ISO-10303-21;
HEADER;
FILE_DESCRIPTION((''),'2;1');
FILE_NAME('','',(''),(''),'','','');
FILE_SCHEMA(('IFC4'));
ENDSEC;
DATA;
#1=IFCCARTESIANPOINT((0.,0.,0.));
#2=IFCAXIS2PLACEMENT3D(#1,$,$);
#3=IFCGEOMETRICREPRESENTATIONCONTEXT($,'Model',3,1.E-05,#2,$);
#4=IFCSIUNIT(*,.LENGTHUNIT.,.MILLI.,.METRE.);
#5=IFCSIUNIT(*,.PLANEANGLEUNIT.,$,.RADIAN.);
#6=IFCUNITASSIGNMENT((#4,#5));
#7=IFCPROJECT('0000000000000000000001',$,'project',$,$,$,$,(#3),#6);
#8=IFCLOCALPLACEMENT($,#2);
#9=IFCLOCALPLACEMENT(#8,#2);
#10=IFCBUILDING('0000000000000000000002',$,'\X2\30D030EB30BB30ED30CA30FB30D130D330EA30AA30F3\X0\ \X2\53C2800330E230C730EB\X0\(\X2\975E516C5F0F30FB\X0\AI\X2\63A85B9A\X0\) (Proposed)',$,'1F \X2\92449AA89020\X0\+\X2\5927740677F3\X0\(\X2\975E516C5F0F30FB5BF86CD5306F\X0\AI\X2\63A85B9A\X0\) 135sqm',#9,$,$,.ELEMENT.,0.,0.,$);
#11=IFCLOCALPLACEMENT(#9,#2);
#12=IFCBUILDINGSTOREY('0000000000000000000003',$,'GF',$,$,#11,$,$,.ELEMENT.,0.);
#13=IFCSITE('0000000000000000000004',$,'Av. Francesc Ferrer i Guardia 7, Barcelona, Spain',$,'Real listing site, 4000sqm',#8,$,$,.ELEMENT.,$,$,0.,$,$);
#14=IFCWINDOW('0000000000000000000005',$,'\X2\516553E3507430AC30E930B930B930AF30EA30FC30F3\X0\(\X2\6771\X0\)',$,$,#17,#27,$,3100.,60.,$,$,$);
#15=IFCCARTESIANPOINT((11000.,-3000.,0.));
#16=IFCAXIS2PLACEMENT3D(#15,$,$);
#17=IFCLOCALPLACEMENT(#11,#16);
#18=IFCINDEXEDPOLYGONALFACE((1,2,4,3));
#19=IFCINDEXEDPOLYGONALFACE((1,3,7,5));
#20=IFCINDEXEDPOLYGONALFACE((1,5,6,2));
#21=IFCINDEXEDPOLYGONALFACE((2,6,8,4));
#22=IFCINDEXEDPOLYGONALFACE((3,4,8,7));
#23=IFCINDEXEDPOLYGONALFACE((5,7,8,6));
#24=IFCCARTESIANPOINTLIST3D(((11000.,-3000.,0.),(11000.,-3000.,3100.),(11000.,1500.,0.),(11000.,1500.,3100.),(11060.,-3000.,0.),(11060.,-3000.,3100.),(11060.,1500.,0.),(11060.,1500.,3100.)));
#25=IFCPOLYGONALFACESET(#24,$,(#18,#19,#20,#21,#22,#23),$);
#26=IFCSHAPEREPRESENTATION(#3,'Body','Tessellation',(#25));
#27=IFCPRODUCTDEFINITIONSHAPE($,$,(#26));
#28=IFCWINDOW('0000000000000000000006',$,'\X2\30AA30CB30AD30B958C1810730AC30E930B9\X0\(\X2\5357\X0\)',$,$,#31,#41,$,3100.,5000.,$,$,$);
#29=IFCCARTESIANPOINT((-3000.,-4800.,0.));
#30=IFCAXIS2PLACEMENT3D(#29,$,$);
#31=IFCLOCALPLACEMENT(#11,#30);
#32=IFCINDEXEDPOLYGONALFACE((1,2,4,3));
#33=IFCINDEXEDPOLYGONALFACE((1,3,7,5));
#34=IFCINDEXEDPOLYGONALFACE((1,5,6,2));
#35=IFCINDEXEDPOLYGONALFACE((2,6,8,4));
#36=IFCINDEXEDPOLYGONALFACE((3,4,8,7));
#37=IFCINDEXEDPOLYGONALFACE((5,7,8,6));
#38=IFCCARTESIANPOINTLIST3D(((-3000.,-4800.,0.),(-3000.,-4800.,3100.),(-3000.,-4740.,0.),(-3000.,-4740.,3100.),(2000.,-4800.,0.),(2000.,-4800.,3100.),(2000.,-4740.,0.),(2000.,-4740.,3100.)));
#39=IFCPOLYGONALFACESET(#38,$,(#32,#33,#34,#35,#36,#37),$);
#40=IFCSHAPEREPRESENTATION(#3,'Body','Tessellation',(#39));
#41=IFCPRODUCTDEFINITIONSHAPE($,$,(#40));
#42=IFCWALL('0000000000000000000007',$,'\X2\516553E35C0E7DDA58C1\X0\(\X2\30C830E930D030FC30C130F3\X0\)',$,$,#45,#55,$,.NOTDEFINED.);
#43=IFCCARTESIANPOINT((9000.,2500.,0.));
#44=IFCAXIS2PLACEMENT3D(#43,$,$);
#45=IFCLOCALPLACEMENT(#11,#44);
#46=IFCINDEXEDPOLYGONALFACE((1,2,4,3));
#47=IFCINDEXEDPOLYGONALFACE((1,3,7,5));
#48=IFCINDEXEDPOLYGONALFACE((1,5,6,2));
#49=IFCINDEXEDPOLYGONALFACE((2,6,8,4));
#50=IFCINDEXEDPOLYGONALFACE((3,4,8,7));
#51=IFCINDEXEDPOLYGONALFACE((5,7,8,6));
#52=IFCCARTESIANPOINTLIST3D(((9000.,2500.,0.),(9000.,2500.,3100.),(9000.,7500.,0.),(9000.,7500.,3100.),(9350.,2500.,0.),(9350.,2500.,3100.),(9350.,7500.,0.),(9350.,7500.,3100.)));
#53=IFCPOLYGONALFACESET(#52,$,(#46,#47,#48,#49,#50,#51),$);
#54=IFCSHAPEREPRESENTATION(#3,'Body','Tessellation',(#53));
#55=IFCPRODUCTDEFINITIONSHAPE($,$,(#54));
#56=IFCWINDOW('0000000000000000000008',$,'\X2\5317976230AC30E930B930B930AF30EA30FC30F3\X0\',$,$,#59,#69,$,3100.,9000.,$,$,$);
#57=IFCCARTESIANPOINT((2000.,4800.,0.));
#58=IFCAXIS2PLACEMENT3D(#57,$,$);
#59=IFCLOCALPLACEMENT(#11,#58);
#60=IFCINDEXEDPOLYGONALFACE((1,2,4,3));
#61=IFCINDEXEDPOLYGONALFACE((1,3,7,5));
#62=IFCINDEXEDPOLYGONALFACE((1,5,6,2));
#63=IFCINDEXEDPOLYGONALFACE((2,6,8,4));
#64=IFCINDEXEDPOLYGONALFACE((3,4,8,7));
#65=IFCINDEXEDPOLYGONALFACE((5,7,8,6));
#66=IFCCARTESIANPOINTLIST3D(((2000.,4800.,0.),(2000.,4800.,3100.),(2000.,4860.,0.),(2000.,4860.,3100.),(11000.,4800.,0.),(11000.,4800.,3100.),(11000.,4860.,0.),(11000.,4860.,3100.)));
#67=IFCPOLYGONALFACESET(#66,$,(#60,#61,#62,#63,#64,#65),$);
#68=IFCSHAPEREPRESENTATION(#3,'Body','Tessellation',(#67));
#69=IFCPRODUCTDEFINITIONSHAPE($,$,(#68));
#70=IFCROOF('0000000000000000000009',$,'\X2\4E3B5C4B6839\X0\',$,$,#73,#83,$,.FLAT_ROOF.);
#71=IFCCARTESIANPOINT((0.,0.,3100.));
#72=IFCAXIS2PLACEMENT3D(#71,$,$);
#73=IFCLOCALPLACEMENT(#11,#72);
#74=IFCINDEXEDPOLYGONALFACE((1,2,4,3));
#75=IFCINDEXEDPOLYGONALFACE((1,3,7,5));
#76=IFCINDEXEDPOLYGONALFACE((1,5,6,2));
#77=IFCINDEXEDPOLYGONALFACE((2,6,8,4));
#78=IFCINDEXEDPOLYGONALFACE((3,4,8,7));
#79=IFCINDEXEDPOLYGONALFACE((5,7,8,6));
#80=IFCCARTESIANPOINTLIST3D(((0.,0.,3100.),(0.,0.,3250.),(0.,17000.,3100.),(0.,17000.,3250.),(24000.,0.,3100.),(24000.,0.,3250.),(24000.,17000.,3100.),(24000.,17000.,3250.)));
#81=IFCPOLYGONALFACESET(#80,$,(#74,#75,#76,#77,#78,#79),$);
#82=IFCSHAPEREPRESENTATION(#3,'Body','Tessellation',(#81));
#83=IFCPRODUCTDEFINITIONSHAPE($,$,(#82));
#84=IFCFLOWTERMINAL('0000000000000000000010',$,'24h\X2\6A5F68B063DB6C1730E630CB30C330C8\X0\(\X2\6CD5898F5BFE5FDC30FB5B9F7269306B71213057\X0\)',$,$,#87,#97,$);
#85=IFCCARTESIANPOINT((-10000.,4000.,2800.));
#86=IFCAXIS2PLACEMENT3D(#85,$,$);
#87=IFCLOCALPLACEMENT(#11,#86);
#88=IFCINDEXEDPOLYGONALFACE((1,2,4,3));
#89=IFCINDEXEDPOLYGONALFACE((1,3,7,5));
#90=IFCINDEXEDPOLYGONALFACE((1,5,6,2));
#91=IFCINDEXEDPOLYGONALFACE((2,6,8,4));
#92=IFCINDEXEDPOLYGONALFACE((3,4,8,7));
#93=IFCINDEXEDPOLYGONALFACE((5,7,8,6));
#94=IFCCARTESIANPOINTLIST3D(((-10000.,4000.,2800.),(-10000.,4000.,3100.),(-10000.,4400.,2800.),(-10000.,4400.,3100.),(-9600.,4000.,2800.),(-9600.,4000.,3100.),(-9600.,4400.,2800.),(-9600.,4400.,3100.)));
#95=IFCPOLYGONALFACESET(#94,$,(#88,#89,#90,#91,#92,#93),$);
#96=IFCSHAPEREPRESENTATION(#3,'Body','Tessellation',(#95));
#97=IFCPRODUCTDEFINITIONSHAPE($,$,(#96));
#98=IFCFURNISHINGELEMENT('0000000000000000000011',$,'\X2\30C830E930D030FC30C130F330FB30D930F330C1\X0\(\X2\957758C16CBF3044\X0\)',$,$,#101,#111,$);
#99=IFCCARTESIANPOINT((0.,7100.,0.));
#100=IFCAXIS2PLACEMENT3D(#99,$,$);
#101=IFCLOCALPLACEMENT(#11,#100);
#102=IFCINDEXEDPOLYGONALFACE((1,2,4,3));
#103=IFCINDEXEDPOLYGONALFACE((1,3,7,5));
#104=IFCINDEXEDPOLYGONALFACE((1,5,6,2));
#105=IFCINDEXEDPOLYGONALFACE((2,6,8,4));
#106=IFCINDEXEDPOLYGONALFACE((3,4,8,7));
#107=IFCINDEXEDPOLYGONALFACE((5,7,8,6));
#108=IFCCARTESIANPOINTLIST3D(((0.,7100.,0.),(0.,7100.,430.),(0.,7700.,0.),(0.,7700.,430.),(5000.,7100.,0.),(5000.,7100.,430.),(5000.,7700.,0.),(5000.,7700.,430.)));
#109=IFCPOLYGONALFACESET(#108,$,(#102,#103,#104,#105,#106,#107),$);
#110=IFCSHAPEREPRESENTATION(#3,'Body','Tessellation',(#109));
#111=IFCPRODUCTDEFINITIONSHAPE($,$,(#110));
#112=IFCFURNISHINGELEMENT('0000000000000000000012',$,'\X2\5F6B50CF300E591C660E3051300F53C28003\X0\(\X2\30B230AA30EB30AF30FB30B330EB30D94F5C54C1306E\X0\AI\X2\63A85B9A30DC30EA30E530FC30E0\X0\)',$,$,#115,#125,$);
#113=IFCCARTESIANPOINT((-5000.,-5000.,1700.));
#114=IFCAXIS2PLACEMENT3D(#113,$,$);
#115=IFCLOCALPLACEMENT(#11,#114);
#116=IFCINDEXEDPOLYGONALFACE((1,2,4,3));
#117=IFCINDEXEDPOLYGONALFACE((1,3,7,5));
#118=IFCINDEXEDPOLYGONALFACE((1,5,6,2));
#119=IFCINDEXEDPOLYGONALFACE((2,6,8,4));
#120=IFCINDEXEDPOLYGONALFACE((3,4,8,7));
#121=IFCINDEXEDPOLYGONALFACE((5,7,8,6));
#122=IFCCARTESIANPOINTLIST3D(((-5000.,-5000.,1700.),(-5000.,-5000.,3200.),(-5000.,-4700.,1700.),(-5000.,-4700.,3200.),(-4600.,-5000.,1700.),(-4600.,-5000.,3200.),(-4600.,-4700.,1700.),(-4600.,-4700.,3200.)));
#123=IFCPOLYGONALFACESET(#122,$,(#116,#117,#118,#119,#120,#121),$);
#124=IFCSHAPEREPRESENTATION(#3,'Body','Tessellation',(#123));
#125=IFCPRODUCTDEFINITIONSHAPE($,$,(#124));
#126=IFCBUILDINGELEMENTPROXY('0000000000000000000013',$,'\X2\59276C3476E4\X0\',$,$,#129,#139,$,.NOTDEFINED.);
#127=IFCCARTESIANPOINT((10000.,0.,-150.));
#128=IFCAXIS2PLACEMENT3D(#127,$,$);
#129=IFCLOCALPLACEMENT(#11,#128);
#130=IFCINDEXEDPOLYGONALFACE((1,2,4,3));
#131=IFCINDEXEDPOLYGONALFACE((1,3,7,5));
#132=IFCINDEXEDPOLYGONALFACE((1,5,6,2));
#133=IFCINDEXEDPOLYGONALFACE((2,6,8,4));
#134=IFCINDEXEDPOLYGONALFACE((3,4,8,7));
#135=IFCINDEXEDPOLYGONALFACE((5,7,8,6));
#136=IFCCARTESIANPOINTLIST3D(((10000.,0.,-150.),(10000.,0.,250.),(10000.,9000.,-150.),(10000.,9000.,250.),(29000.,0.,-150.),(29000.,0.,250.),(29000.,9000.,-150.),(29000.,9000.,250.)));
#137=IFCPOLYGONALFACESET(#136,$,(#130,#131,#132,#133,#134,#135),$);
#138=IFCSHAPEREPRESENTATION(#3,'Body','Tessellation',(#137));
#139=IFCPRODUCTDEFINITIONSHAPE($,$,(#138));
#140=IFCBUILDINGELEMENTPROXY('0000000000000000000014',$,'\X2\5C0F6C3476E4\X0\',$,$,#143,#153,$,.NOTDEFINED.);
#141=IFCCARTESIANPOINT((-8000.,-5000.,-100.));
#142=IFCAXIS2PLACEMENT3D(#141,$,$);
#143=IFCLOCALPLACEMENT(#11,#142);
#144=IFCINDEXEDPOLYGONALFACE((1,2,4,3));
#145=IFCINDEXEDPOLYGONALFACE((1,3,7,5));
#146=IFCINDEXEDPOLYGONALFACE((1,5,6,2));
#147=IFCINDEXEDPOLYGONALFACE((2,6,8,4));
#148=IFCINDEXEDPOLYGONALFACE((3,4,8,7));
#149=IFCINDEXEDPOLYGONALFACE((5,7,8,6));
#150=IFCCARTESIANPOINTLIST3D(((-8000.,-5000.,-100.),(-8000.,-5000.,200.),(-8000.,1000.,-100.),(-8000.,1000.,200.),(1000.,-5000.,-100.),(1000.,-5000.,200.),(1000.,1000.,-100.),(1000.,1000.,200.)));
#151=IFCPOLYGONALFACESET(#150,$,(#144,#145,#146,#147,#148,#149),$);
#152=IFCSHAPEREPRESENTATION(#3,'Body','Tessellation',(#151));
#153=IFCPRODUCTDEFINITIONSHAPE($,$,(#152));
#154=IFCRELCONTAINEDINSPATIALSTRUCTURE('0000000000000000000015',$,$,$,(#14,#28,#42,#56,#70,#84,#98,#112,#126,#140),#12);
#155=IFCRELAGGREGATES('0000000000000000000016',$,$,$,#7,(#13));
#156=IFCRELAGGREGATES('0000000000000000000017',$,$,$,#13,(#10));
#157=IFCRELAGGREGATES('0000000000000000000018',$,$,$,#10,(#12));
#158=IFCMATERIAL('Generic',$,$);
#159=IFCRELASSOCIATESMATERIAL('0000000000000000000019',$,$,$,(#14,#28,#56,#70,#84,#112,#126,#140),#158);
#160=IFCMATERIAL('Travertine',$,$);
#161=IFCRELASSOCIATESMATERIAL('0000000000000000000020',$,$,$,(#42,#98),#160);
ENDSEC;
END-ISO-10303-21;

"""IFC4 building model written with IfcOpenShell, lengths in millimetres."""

from ifc_helpers import new_model, si_unit, frame, frame_2d, origin, place, context, project, spatial, rectangle, extrude, material, element, fill, save


model = new_model("IFC4")

# Units and contexts
model_context = context("Model", 3, precision=1e-05, world=origin())
ifc_project = project(units=[si_unit("LENGTHUNIT", "METRE", prefix="MILLI"), si_unit("PLANEANGLEUNIT", "RADIAN")], contexts=[model_context])

# Site, building, storey
site_placement = place(None, origin())
site = spatial("IfcSite", under=ifc_project, at=site_placement, Name="Av. Francesc Ferrer i Guardia 7, Barcelona, Spain", ObjectType="Real listing site, 4000sqm", CompositionType="ELEMENT", RefElevation=0.0)
building_placement = place(site_placement, origin())
building = spatial("IfcBuilding", under=site, at=building_placement, Name="バルセロナ・パビリオン 参考モデル(非公式・AI推定) (Proposed)", ObjectType="1F 鉄骨造+大理石(非公式・寸法はAI推定) 135sqm", CompositionType="ELEMENT", ElevationOfRefHeight=0.0, ElevationOfTerrain=0.0)
storey_placement = place(building_placement, origin())
storey = spatial("IfcBuildingStorey", under=building, at=storey_placement, Name="GF", CompositionType="ELEMENT", Elevation=0.0)

# Shared definitions
ifc_material_1 = material(Name="Travertine")

# Shared definitions
ifc_material_2 = material(Name="Generic")

# Windows
window_1_placement = place(storey_placement, frame((11000.0, -3000.0, 0.0)))
element("IfcWindow", 1, at=window_1_placement, inside=storey, material=ifc_material_2, Name="入口側ガラススクリーン(東)", OverallHeight=3100.0, OverallWidth=60.0, context=model_context, shape_type="SweptSolid", body=[
    extrude(rectangle(XDim=60.0, YDim=4500.0, at=frame_2d((30.0, 2250.0))), frame((11000.0, -3000.0, 0.0)), (0.0, 0.0, 1.0), 3100.0),
])
window_2_placement = place(storey_placement, frame((-3000.0, -4800.0, 0.0)))
element("IfcWindow", 2, at=window_2_placement, inside=storey, material=ifc_material_2, Name="オニキス壁脇ガラス(南)", OverallHeight=3100.0, OverallWidth=5000.0, context=model_context, shape_type="SweptSolid", body=[
    extrude(rectangle(XDim=5000.0, YDim=60.0, at=frame_2d((2500.0, 30.0))), frame((-3000.0, -4800.0, 0.0)), (0.0, 0.0, 1.0), 3100.0),
])

# Wall, opening, window
wall_1_placement = place(storey_placement, frame((9000.0, 2500.0, 0.0)))
wall_1 = element("IfcWall", 3, at=wall_1_placement, inside=storey, material=ifc_material_1, Name="入口導線壁(トラバーチン)", PredefinedType="NOTDEFINED", context=model_context, shape_type="SweptSolid", body=[
    extrude(rectangle(XDim=350.0, YDim=5000.0, at=frame_2d((175.0, 2500.0))), frame((9000.0, 2500.0, 0.0)), (0.0, 0.0, 1.0), 3100.0),
])
opening_1_placement = place(storey_placement, frame((2000.0, 4800.0, 0.0)))
opening_1 = element("IfcOpeningElement", 4, at=opening_1_placement, cuts=wall_1, PredefinedType="NOTDEFINED", context=model_context, shape_type="SweptSolid", body=[
    extrude(rectangle(XDim=9000.0, YDim=60.0, at=frame_2d((4500.0, 30.0))), frame((2000.0, 4800.0, 0.0)), (0.0, 0.0, 1.0), 3100.0),
])
window_3_placement = place(storey_placement, frame((2000.0, 4800.0, 0.0)))
window_3 = element("IfcWindow", 5, at=window_3_placement, inside=storey, material=ifc_material_2, Name="北面ガラススクリーン", OverallHeight=3100.0, OverallWidth=9000.0, context=model_context, shape_type="SweptSolid", body=[
    extrude(rectangle(XDim=9000.0, YDim=60.0, at=frame_2d((4500.0, 30.0))), frame((2000.0, 4800.0, 0.0)), (0.0, 0.0, 1.0), 3100.0),
])
fill(opening_1, window_3)

# Roof
roof_placement = place(storey_placement, frame((0.0, 0.0, 3100.0)))
element("IfcRoof", 6, at=roof_placement, inside=storey, material=ifc_material_2, Name="主屋根", PredefinedType="FLAT_ROOF", context=model_context, shape_type="SweptSolid", body=[
    extrude(rectangle(XDim=24000.0, YDim=17000.0, at=frame_2d((12000.0, 8500.0))), frame((0.0, 0.0, 3100.0)), (0.0, 0.0, 1.0), 150.0),
])

# Flow terminal
flow_terminal_placement = place(storey_placement, frame((-10000.0, 4000.0, 2800.0)))
element("IfcFlowTerminal", 7, at=flow_terminal_placement, inside=storey, material=ifc_material_2, Name="24h機械換気ユニット(法規対応・実物に無し)", context=model_context, shape_type="SweptSolid", body=[
    extrude(rectangle(XDim=400.0, YDim=400.0, at=frame_2d((200.0, 200.0))), frame((-10000.0, 4000.0, 2800.0)), (0.0, 0.0, 1.0), 300.0),
])

# Furnishing elements
furnishing_1_placement = place(storey_placement, frame((0.0, 7100.0, 0.0)))
element("IfcFurnishingElement", 8, at=furnishing_1_placement, inside=storey, material=ifc_material_1, Name="トラバーチン・ベンチ(長壁沿い)", context=model_context, shape_type="SweptSolid", body=[
    extrude(rectangle(XDim=5000.0, YDim=600.0, at=frame_2d((2500.0, 300.0))), frame((0.0, 7100.0, 0.0)), (0.0, 0.0, 1.0), 430.0),
])
furnishing_2_placement = place(storey_placement, frame((-5000.0, -5000.0, 1700.0)))
element("IfcFurnishingElement", 9, at=furnishing_2_placement, inside=storey, material=ifc_material_2, Name="彫像『夜明け』参考(ゲオルク・コルベ作品のAI推定ボリューム)", context=model_context, shape_type="SweptSolid", body=[
    extrude(rectangle(XDim=400.0, YDim=300.0, at=frame_2d((200.0, 150.0))), frame((-5000.0, -5000.0, 1700.0)), (0.0, 0.0, 1.0), 1500.0),
])

# Building element proxies
proxy_1_placement = place(storey_placement, frame((10000.0, 0.0, -150.0)))
element("IfcBuildingElementProxy", 10, at=proxy_1_placement, inside=storey, material=ifc_material_2, Name="大水盤", PredefinedType="NOTDEFINED", context=model_context, shape_type="SweptSolid", body=[
    extrude(rectangle(XDim=19000.0, YDim=9000.0, at=frame_2d((9500.0, 4500.0))), frame((10000.0, 0.0, -150.0)), (0.0, 0.0, 1.0), 400.0),
])
proxy_2_placement = place(storey_placement, frame((-8000.0, -5000.0, -100.0)))
element("IfcBuildingElementProxy", 11, at=proxy_2_placement, inside=storey, material=ifc_material_2, Name="小水盤", PredefinedType="NOTDEFINED", context=model_context, shape_type="SweptSolid", body=[
    extrude(rectangle(XDim=9000.0, YDim=6000.0, at=frame_2d((4500.0, 3000.0))), frame((-8000.0, -5000.0, -100.0)), (0.0, 0.0, 1.0), 300.0),
])

save(model, "model.ifc")
